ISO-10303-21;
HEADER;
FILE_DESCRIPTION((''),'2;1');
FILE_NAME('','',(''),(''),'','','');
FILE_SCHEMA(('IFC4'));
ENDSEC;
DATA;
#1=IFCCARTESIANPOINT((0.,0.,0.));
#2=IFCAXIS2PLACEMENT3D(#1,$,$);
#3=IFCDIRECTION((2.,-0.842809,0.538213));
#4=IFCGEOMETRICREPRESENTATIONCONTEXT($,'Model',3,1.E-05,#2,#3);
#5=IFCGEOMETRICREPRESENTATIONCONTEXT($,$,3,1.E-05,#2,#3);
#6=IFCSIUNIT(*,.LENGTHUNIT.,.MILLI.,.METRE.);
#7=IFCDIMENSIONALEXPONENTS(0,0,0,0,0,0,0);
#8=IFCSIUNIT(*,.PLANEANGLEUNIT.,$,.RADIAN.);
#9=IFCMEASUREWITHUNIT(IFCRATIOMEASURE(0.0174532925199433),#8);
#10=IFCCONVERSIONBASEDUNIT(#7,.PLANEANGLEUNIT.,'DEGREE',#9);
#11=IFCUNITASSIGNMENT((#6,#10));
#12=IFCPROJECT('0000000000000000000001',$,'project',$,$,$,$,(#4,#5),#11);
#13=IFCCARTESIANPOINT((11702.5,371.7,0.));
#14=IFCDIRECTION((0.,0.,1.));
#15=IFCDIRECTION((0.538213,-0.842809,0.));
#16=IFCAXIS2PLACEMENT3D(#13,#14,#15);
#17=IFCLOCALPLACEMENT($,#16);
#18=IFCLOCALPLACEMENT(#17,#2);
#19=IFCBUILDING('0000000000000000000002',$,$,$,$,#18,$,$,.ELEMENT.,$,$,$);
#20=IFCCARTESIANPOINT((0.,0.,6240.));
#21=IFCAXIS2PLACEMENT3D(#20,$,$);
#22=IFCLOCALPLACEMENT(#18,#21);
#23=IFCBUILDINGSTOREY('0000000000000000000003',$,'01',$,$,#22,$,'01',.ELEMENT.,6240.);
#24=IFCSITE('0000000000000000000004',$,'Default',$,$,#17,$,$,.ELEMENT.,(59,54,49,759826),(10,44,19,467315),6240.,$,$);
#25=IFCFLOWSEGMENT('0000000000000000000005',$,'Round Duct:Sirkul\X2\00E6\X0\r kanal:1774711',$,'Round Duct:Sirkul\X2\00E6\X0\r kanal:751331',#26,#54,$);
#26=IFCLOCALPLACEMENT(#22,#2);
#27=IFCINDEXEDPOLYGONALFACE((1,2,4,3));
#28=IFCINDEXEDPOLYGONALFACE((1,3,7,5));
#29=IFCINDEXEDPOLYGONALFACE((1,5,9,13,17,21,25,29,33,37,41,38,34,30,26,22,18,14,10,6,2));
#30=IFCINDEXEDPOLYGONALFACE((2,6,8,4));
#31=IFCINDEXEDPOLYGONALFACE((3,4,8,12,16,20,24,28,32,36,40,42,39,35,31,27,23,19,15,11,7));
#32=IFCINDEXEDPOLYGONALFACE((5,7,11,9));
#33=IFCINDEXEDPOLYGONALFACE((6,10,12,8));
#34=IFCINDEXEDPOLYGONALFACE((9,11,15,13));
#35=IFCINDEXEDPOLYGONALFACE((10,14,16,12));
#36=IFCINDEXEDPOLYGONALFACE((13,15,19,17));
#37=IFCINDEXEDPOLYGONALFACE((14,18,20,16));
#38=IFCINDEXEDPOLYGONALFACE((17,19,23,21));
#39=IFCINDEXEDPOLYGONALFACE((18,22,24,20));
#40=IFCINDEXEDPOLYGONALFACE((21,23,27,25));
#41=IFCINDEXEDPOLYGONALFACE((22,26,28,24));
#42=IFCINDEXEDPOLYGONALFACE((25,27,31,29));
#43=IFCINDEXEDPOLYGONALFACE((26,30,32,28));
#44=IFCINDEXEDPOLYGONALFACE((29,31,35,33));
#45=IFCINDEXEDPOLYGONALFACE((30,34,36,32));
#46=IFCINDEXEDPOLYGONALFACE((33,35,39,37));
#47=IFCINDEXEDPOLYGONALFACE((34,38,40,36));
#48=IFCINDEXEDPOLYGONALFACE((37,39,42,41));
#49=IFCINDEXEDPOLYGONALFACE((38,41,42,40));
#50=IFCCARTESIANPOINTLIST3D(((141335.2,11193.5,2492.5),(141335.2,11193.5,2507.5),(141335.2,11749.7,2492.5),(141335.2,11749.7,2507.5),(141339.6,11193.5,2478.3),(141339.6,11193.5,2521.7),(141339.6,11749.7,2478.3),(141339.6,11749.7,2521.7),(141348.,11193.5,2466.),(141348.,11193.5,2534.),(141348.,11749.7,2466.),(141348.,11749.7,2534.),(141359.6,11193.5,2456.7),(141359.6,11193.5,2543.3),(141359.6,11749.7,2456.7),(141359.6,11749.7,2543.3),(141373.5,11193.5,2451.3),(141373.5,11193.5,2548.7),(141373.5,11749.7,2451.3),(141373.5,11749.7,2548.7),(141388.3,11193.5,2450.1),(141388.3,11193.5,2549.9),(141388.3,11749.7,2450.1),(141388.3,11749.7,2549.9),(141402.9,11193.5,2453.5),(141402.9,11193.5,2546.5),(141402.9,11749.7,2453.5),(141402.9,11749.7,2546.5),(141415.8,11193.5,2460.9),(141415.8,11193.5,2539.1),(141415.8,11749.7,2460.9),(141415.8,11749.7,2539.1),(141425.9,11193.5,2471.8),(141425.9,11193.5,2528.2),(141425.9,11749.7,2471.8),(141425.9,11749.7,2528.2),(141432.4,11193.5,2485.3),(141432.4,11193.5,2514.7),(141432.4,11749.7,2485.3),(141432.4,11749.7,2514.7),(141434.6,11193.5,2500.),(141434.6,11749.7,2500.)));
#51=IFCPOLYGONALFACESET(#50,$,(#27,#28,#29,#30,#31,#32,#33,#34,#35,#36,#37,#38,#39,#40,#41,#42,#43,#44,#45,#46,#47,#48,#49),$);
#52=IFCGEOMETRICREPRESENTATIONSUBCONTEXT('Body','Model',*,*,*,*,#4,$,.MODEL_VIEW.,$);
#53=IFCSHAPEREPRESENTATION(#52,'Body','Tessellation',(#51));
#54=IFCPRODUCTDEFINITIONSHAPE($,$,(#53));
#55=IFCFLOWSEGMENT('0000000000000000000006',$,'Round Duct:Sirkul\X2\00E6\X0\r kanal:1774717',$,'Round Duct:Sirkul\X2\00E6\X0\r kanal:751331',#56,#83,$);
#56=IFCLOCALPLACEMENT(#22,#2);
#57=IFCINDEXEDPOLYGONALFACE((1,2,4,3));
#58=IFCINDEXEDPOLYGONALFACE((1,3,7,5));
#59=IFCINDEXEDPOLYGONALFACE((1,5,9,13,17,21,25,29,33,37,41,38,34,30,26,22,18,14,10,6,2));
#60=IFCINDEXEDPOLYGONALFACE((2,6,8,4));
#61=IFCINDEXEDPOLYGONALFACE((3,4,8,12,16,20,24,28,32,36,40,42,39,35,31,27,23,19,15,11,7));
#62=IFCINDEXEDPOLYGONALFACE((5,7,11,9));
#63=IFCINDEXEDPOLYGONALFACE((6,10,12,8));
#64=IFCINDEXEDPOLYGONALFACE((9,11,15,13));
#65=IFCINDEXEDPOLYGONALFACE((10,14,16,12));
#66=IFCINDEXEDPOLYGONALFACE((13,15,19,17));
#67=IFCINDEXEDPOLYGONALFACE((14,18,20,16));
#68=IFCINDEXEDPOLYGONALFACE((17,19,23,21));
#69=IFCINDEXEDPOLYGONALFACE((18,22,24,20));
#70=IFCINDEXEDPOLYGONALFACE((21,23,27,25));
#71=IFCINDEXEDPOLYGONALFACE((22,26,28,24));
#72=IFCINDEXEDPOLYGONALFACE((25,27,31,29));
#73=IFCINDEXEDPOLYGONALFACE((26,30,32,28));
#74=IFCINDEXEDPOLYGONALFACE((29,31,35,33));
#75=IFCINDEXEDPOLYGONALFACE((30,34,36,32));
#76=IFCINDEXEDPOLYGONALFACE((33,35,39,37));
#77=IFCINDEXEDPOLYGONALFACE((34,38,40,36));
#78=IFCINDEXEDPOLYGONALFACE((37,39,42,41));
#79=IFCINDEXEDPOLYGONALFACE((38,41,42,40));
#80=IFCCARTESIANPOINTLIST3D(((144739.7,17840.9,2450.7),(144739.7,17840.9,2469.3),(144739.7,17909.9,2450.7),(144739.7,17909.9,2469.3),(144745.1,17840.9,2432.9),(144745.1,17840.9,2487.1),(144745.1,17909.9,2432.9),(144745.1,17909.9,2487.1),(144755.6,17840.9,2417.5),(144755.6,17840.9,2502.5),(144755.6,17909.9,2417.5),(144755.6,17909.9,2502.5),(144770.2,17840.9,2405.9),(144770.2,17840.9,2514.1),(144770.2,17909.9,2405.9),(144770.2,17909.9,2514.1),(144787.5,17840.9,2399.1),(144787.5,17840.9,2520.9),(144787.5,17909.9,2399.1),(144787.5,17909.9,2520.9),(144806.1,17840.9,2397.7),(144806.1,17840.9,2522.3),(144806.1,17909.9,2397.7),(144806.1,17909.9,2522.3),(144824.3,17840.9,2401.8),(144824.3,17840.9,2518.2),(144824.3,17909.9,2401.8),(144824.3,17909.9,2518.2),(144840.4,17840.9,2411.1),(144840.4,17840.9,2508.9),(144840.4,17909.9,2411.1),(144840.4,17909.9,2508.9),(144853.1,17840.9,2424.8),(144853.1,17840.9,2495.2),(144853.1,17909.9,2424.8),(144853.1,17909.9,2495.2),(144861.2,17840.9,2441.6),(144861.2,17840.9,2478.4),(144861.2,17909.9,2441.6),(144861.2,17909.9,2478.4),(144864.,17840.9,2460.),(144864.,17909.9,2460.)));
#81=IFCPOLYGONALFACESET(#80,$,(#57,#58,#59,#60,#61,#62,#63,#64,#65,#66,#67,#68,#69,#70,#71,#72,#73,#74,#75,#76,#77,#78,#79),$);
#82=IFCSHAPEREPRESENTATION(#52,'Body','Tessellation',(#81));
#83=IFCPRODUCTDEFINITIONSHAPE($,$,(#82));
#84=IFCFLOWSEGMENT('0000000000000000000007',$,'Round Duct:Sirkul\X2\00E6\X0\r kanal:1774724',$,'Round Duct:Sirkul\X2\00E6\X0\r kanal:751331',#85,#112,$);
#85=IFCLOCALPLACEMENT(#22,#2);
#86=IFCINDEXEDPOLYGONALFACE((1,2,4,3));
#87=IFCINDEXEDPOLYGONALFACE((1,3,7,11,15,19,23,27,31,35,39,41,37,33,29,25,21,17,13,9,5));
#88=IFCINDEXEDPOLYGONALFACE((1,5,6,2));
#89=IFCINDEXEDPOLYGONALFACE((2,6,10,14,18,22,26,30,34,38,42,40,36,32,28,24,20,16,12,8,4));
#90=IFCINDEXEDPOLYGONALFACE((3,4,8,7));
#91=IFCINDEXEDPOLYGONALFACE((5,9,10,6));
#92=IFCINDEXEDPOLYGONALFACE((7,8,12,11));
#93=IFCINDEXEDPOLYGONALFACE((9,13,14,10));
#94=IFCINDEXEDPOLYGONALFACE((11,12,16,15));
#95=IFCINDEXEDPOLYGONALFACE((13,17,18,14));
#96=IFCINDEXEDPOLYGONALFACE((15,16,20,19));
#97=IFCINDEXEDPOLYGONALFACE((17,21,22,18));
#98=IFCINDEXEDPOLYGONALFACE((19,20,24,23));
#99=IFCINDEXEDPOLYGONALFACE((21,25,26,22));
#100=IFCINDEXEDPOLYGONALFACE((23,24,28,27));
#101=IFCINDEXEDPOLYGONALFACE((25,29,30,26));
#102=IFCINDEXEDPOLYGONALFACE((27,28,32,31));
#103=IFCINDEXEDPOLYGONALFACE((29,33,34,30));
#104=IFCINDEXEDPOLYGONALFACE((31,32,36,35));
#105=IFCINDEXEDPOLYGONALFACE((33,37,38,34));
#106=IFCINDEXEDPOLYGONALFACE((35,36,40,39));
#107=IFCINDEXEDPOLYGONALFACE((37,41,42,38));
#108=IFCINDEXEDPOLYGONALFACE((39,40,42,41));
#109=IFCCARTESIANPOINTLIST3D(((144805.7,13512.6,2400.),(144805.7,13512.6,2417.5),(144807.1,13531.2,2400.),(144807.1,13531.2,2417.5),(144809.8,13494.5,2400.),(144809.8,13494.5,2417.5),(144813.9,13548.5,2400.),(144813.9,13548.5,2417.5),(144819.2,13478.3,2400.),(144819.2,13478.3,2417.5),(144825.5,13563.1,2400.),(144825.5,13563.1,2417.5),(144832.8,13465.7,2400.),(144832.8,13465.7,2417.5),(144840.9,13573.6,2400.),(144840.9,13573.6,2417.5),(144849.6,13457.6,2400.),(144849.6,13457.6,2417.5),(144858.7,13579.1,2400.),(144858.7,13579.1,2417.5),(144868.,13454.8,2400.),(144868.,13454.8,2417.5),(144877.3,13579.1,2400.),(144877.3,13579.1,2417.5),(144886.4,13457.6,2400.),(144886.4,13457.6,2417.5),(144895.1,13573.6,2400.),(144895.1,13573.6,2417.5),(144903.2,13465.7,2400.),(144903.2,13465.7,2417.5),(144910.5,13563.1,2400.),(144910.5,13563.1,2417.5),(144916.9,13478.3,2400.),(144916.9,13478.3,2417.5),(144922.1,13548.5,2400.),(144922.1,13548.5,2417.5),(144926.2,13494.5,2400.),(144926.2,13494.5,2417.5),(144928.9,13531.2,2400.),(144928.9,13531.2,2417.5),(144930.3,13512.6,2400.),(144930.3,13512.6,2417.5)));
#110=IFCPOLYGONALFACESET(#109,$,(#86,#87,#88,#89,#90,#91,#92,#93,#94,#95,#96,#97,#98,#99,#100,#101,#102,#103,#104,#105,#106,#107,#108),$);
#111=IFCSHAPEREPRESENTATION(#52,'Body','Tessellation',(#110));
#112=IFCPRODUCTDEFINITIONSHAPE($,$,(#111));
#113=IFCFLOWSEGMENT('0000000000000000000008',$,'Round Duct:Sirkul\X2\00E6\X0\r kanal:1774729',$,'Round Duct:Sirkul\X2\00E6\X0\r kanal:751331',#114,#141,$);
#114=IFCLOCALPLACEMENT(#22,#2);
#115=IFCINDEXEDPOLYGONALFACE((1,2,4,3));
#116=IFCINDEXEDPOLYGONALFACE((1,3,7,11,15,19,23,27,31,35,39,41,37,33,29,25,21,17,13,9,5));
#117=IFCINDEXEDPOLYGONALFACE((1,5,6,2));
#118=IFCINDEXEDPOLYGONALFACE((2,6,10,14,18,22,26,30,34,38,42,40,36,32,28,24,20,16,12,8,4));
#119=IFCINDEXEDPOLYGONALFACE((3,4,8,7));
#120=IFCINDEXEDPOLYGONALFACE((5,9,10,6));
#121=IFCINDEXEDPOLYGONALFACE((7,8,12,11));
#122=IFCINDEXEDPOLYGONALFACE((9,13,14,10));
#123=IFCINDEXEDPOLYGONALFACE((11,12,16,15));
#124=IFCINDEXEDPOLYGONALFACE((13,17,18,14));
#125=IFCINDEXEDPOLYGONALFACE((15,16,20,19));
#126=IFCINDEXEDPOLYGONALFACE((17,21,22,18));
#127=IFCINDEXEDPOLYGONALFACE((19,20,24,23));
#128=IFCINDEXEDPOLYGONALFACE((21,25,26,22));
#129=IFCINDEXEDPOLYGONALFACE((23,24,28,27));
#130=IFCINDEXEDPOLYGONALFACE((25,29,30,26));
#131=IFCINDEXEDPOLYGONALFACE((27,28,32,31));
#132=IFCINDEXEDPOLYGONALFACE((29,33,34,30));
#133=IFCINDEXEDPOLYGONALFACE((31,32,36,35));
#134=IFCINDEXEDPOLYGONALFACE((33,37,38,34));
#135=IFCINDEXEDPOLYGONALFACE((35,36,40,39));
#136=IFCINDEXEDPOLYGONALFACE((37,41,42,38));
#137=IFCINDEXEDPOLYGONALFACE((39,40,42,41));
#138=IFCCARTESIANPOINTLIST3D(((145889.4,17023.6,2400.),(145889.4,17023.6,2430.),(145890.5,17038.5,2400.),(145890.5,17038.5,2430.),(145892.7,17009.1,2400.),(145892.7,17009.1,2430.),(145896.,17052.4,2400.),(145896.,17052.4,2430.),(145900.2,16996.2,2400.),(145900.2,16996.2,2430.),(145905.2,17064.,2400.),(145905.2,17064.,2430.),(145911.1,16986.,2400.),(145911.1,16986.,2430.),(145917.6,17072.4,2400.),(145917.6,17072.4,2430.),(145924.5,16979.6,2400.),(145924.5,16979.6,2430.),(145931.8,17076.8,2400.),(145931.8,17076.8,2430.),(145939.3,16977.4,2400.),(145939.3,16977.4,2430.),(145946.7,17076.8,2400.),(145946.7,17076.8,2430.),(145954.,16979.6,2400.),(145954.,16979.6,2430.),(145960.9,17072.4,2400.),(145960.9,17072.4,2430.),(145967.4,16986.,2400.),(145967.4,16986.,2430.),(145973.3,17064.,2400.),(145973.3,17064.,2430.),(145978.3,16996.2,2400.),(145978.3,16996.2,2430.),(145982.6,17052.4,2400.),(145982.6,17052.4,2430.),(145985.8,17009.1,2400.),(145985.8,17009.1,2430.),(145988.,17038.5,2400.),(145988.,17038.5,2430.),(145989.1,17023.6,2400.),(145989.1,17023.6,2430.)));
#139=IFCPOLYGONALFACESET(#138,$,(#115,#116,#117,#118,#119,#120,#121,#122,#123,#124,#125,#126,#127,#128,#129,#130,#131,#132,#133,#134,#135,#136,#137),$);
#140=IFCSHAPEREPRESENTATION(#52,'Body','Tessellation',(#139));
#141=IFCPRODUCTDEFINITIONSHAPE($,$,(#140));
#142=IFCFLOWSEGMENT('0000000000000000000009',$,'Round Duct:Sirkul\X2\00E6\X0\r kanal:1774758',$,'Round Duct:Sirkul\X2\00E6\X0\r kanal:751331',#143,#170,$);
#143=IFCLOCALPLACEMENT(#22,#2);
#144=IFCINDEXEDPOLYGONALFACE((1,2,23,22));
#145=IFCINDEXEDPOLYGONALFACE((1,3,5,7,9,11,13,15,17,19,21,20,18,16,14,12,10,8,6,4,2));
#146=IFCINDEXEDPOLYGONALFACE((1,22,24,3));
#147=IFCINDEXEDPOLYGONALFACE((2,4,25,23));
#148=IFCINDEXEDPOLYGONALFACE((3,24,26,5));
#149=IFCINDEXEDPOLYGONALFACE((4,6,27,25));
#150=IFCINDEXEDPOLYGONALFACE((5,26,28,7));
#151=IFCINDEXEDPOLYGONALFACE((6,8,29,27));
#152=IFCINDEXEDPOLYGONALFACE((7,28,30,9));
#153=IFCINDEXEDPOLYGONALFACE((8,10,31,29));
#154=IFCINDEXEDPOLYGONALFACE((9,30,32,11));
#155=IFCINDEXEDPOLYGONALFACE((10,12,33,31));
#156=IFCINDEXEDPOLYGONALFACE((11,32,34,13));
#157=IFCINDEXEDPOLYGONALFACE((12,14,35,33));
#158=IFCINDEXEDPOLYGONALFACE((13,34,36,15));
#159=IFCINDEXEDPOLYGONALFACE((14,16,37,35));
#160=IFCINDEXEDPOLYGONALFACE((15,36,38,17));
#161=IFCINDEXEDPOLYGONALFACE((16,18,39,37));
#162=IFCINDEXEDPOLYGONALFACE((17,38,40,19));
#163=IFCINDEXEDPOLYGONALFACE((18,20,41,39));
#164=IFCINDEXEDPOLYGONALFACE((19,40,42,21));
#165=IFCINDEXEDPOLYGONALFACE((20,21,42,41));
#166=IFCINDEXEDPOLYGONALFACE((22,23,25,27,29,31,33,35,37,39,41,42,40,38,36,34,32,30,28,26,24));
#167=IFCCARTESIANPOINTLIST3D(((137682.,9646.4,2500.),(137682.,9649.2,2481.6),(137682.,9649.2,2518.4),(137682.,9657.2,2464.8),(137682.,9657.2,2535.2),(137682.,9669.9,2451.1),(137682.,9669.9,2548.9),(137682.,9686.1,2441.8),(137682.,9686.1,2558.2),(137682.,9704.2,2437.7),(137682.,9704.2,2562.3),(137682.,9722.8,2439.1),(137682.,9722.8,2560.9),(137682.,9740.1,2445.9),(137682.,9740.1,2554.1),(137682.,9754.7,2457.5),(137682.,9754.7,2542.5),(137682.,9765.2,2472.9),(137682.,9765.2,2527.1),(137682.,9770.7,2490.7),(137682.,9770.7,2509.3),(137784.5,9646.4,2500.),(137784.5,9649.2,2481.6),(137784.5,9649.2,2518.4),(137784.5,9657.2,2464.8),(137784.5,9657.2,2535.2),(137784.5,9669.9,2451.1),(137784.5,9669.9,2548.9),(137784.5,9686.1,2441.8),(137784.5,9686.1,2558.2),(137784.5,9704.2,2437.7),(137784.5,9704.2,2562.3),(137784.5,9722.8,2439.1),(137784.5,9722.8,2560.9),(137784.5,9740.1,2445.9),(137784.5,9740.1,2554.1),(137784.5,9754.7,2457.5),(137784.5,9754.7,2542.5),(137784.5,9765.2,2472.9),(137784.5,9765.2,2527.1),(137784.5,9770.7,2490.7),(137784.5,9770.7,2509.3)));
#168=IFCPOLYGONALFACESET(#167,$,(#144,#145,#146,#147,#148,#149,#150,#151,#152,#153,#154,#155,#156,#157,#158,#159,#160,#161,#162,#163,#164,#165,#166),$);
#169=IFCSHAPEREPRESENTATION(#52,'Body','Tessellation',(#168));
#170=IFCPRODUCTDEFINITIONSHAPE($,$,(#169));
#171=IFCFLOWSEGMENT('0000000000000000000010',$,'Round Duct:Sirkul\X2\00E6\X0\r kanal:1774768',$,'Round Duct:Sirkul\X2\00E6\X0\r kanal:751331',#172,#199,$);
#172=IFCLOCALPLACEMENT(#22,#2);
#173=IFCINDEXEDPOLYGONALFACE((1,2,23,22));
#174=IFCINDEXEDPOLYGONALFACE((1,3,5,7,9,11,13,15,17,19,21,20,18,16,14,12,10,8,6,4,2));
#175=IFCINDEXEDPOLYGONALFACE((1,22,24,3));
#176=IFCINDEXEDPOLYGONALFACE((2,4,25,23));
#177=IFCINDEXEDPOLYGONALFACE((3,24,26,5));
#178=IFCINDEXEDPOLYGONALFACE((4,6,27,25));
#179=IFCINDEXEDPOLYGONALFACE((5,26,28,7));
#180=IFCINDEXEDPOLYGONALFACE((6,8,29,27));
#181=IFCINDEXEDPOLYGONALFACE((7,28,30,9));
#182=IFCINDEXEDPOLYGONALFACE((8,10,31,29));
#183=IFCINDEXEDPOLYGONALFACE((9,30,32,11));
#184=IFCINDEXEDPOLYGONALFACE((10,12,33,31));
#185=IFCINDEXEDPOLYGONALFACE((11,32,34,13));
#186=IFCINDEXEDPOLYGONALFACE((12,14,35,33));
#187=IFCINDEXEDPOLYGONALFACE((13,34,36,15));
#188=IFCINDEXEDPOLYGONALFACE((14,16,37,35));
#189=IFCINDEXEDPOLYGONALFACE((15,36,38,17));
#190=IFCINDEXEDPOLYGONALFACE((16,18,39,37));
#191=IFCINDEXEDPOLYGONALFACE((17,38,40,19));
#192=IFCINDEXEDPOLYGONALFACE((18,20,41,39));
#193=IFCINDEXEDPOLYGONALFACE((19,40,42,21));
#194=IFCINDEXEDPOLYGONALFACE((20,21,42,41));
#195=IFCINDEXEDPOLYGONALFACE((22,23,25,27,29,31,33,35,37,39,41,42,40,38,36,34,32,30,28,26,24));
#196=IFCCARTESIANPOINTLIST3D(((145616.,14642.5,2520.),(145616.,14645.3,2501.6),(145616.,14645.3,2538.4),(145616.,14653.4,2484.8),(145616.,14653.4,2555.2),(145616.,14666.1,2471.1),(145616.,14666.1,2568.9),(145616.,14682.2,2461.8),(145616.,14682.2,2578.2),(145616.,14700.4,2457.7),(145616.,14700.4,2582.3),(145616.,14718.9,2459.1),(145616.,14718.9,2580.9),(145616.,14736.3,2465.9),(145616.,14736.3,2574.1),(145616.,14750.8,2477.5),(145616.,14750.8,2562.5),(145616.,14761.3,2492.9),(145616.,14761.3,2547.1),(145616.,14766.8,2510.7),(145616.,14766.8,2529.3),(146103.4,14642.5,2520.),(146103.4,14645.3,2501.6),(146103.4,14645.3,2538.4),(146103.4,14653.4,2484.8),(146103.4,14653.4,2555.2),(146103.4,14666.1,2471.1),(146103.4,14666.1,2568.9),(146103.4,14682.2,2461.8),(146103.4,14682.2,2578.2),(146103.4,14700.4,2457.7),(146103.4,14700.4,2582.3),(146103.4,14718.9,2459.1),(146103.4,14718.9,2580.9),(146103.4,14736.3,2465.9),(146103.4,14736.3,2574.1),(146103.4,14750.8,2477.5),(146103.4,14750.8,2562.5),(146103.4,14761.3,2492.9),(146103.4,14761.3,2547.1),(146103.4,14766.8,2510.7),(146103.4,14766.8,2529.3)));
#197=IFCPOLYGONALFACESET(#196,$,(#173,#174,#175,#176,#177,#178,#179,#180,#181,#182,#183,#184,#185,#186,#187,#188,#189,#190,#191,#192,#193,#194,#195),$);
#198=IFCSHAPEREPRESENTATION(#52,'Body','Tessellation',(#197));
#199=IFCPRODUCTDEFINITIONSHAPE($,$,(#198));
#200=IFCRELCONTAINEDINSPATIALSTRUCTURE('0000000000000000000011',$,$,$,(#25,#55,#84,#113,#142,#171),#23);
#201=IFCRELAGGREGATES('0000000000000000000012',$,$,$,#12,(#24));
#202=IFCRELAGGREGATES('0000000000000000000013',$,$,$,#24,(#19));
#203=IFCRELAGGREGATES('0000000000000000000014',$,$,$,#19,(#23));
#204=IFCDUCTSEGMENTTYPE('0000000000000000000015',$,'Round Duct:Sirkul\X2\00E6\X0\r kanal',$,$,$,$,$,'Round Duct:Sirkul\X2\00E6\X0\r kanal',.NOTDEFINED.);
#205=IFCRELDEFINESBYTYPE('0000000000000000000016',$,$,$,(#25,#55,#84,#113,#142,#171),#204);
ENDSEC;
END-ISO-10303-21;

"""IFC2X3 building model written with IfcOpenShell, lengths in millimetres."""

from ifc_helpers import new_model, entity, si_unit, converted_unit, direction, frame, frame_2d, origin, origin_2d_with_axis, place, context, subcontext, project, spatial, circle, extrude, type_object, element, save


model = new_model("IFC2X3")

# Units and contexts
model_context = context("Model", 3, precision=1e-05, world=origin(), true_north=direction((2.0, -0.842809, 0.538213)))
context_of_model = context(None, 3, precision=1e-05, world=origin(), true_north=direction((2.0, -0.842809, 0.538213)))
body_context = subcontext(model_context, "Body", "Model", "MODEL_VIEW")
ifc_project = project(units=[si_unit("LENGTHUNIT", "METRE", prefix="MILLI"), converted_unit("PLANEANGLEUNIT", "DEGREE", entity("IfcRatioMeasure", 0.0174532925199433), si_unit("PLANEANGLEUNIT", "RADIAN"), dimensions=[0, 0, 0, 0, 0, 0, 0])], contexts=[model_context, context_of_model])

# Site, building, storey
site_placement = place(None, frame((11702.5, 371.7, 0.0), z_axis=(0.0, 0.0, 1.0), x_axis=(0.538213, -0.842809, 0.0)))
site = spatial("IfcSite", under=ifc_project, at=site_placement, Name="Default", CompositionType="ELEMENT", RefLatitude=(59, 54, 49, 759826), RefLongitude=(10, 44, 19, 467315), RefElevation=6240.0)
building_placement = place(site_placement, origin())
building = spatial("IfcBuilding", under=site, at=building_placement, CompositionType="ELEMENT")
storey_placement = place(building_placement, frame((0.0, 0.0, 6240.0)))
storey = spatial("IfcBuildingStorey", under=building, at=storey_placement, Name="01", LongName="01", CompositionType="ELEMENT", Elevation=6240.0)

# Flow segments
duct_segment_type = type_object("IfcDuctSegmentType", Name="Round Duct:Sirkulær kanal", ElementType="Round Duct:Sirkulær kanal", PredefinedType="NOTDEFINED")
flow_segment_1_placement = place(storey_placement, origin())
element("IfcFlowSegment", 1, at=flow_segment_1_placement, inside=storey, type_object=duct_segment_type, Name="Round Duct:Sirkulær kanal:1774711", ObjectType="Round Duct:Sirkulær kanal:751331", context=body_context, shape_type="SweptSolid", body=[
    extrude(circle(Radius=50.0, at=origin_2d_with_axis()), frame((141384.6, 11193.5, 2500.0), z_axis=(0.0, 1.0, 0.0), x_axis=(1.0, 0.0, 0.0)), (0.0, 0.0, 1.0), 556.2),
])
flow_segment_2_placement = place(storey_placement, origin())
element("IfcFlowSegment", 2, at=flow_segment_2_placement, inside=storey, type_object=duct_segment_type, Name="Round Duct:Sirkulær kanal:1774717", ObjectType="Round Duct:Sirkulær kanal:751331", context=body_context, shape_type="SweptSolid", body=[
    extrude(circle(Radius=62.5, at=frame_2d((0.0, 0.0), x_axis=(1.0, 0.0))), frame((144801.5, 17840.9, 2460.0), z_axis=(0.0, 1.0, 0.0), x_axis=(1.0, 0.0, 0.0)), (0.0, 0.0, 1.0), 69.0),
])
flow_segment_3_placement = place(storey_placement, origin())
element("IfcFlowSegment", 3, at=flow_segment_3_placement, inside=storey, type_object=duct_segment_type, Name="Round Duct:Sirkulær kanal:1774724", ObjectType="Round Duct:Sirkulær kanal:751331", context=body_context, shape_type="SweptSolid", body=[
    extrude(circle(Radius=62.5, at=frame_2d((0.0, 0.0), x_axis=(1.0, 0.0))), frame((144868.0, 13517.3, 2400.0), z_axis=(0.0, 0.0, 1.0), x_axis=(0.0, -1.0, 0.0)), (0.0, 0.0, 1.0), 17.5),
])
flow_segment_4_placement = place(storey_placement, origin())
element("IfcFlowSegment", 4, at=flow_segment_4_placement, inside=storey, type_object=duct_segment_type, Name="Round Duct:Sirkulær kanal:1774729", ObjectType="Round Duct:Sirkulær kanal:751331", context=body_context, shape_type="SweptSolid", body=[
    extrude(circle(Radius=50.0, at=frame_2d((0.0, 0.0), x_axis=(1.0, 0.0))), frame((145939.3, 17027.4, 2400.0), z_axis=(0.0, 0.0, 1.0), x_axis=(0.0, -1.0, 0.0)), (0.0, 0.0, 1.0), 30.0),
])
flow_segment_5_placement = place(storey_placement, origin())
element("IfcFlowSegment", 5, at=flow_segment_5_placement, inside=storey, type_object=duct_segment_type, Name="Round Duct:Sirkulær kanal:1774758", ObjectType="Round Duct:Sirkulær kanal:751331", context=body_context, shape_type="SweptSolid", body=[
    extrude(circle(Radius=62.5, at=frame_2d((0.0, 0.0), x_axis=(1.0, 0.0))), frame((137682.0, 9708.9, 2500.0), z_axis=(1.0, 0.0, 0.0), x_axis=(0.0, -1.0, 0.0)), (0.0, 0.0, 1.0), 102.5),
])
flow_segment_6_placement = place(storey_placement, origin())
element("IfcFlowSegment", 6, at=flow_segment_6_placement, inside=storey, type_object=duct_segment_type, Name="Round Duct:Sirkulær kanal:1774768", ObjectType="Round Duct:Sirkulær kanal:751331", context=body_context, shape_type="SweptSolid", body=[
    extrude(circle(Radius=62.5, at=frame_2d((0.0, 0.0), x_axis=(1.0, 0.0))), frame((145616.0, 14705.0, 2520.0), z_axis=(1.0, 0.0, 0.0), x_axis=(0.0, -1.0, 0.0)), (0.0, 0.0, 1.0), 487.5),
])

save(model, "model.ifc")
